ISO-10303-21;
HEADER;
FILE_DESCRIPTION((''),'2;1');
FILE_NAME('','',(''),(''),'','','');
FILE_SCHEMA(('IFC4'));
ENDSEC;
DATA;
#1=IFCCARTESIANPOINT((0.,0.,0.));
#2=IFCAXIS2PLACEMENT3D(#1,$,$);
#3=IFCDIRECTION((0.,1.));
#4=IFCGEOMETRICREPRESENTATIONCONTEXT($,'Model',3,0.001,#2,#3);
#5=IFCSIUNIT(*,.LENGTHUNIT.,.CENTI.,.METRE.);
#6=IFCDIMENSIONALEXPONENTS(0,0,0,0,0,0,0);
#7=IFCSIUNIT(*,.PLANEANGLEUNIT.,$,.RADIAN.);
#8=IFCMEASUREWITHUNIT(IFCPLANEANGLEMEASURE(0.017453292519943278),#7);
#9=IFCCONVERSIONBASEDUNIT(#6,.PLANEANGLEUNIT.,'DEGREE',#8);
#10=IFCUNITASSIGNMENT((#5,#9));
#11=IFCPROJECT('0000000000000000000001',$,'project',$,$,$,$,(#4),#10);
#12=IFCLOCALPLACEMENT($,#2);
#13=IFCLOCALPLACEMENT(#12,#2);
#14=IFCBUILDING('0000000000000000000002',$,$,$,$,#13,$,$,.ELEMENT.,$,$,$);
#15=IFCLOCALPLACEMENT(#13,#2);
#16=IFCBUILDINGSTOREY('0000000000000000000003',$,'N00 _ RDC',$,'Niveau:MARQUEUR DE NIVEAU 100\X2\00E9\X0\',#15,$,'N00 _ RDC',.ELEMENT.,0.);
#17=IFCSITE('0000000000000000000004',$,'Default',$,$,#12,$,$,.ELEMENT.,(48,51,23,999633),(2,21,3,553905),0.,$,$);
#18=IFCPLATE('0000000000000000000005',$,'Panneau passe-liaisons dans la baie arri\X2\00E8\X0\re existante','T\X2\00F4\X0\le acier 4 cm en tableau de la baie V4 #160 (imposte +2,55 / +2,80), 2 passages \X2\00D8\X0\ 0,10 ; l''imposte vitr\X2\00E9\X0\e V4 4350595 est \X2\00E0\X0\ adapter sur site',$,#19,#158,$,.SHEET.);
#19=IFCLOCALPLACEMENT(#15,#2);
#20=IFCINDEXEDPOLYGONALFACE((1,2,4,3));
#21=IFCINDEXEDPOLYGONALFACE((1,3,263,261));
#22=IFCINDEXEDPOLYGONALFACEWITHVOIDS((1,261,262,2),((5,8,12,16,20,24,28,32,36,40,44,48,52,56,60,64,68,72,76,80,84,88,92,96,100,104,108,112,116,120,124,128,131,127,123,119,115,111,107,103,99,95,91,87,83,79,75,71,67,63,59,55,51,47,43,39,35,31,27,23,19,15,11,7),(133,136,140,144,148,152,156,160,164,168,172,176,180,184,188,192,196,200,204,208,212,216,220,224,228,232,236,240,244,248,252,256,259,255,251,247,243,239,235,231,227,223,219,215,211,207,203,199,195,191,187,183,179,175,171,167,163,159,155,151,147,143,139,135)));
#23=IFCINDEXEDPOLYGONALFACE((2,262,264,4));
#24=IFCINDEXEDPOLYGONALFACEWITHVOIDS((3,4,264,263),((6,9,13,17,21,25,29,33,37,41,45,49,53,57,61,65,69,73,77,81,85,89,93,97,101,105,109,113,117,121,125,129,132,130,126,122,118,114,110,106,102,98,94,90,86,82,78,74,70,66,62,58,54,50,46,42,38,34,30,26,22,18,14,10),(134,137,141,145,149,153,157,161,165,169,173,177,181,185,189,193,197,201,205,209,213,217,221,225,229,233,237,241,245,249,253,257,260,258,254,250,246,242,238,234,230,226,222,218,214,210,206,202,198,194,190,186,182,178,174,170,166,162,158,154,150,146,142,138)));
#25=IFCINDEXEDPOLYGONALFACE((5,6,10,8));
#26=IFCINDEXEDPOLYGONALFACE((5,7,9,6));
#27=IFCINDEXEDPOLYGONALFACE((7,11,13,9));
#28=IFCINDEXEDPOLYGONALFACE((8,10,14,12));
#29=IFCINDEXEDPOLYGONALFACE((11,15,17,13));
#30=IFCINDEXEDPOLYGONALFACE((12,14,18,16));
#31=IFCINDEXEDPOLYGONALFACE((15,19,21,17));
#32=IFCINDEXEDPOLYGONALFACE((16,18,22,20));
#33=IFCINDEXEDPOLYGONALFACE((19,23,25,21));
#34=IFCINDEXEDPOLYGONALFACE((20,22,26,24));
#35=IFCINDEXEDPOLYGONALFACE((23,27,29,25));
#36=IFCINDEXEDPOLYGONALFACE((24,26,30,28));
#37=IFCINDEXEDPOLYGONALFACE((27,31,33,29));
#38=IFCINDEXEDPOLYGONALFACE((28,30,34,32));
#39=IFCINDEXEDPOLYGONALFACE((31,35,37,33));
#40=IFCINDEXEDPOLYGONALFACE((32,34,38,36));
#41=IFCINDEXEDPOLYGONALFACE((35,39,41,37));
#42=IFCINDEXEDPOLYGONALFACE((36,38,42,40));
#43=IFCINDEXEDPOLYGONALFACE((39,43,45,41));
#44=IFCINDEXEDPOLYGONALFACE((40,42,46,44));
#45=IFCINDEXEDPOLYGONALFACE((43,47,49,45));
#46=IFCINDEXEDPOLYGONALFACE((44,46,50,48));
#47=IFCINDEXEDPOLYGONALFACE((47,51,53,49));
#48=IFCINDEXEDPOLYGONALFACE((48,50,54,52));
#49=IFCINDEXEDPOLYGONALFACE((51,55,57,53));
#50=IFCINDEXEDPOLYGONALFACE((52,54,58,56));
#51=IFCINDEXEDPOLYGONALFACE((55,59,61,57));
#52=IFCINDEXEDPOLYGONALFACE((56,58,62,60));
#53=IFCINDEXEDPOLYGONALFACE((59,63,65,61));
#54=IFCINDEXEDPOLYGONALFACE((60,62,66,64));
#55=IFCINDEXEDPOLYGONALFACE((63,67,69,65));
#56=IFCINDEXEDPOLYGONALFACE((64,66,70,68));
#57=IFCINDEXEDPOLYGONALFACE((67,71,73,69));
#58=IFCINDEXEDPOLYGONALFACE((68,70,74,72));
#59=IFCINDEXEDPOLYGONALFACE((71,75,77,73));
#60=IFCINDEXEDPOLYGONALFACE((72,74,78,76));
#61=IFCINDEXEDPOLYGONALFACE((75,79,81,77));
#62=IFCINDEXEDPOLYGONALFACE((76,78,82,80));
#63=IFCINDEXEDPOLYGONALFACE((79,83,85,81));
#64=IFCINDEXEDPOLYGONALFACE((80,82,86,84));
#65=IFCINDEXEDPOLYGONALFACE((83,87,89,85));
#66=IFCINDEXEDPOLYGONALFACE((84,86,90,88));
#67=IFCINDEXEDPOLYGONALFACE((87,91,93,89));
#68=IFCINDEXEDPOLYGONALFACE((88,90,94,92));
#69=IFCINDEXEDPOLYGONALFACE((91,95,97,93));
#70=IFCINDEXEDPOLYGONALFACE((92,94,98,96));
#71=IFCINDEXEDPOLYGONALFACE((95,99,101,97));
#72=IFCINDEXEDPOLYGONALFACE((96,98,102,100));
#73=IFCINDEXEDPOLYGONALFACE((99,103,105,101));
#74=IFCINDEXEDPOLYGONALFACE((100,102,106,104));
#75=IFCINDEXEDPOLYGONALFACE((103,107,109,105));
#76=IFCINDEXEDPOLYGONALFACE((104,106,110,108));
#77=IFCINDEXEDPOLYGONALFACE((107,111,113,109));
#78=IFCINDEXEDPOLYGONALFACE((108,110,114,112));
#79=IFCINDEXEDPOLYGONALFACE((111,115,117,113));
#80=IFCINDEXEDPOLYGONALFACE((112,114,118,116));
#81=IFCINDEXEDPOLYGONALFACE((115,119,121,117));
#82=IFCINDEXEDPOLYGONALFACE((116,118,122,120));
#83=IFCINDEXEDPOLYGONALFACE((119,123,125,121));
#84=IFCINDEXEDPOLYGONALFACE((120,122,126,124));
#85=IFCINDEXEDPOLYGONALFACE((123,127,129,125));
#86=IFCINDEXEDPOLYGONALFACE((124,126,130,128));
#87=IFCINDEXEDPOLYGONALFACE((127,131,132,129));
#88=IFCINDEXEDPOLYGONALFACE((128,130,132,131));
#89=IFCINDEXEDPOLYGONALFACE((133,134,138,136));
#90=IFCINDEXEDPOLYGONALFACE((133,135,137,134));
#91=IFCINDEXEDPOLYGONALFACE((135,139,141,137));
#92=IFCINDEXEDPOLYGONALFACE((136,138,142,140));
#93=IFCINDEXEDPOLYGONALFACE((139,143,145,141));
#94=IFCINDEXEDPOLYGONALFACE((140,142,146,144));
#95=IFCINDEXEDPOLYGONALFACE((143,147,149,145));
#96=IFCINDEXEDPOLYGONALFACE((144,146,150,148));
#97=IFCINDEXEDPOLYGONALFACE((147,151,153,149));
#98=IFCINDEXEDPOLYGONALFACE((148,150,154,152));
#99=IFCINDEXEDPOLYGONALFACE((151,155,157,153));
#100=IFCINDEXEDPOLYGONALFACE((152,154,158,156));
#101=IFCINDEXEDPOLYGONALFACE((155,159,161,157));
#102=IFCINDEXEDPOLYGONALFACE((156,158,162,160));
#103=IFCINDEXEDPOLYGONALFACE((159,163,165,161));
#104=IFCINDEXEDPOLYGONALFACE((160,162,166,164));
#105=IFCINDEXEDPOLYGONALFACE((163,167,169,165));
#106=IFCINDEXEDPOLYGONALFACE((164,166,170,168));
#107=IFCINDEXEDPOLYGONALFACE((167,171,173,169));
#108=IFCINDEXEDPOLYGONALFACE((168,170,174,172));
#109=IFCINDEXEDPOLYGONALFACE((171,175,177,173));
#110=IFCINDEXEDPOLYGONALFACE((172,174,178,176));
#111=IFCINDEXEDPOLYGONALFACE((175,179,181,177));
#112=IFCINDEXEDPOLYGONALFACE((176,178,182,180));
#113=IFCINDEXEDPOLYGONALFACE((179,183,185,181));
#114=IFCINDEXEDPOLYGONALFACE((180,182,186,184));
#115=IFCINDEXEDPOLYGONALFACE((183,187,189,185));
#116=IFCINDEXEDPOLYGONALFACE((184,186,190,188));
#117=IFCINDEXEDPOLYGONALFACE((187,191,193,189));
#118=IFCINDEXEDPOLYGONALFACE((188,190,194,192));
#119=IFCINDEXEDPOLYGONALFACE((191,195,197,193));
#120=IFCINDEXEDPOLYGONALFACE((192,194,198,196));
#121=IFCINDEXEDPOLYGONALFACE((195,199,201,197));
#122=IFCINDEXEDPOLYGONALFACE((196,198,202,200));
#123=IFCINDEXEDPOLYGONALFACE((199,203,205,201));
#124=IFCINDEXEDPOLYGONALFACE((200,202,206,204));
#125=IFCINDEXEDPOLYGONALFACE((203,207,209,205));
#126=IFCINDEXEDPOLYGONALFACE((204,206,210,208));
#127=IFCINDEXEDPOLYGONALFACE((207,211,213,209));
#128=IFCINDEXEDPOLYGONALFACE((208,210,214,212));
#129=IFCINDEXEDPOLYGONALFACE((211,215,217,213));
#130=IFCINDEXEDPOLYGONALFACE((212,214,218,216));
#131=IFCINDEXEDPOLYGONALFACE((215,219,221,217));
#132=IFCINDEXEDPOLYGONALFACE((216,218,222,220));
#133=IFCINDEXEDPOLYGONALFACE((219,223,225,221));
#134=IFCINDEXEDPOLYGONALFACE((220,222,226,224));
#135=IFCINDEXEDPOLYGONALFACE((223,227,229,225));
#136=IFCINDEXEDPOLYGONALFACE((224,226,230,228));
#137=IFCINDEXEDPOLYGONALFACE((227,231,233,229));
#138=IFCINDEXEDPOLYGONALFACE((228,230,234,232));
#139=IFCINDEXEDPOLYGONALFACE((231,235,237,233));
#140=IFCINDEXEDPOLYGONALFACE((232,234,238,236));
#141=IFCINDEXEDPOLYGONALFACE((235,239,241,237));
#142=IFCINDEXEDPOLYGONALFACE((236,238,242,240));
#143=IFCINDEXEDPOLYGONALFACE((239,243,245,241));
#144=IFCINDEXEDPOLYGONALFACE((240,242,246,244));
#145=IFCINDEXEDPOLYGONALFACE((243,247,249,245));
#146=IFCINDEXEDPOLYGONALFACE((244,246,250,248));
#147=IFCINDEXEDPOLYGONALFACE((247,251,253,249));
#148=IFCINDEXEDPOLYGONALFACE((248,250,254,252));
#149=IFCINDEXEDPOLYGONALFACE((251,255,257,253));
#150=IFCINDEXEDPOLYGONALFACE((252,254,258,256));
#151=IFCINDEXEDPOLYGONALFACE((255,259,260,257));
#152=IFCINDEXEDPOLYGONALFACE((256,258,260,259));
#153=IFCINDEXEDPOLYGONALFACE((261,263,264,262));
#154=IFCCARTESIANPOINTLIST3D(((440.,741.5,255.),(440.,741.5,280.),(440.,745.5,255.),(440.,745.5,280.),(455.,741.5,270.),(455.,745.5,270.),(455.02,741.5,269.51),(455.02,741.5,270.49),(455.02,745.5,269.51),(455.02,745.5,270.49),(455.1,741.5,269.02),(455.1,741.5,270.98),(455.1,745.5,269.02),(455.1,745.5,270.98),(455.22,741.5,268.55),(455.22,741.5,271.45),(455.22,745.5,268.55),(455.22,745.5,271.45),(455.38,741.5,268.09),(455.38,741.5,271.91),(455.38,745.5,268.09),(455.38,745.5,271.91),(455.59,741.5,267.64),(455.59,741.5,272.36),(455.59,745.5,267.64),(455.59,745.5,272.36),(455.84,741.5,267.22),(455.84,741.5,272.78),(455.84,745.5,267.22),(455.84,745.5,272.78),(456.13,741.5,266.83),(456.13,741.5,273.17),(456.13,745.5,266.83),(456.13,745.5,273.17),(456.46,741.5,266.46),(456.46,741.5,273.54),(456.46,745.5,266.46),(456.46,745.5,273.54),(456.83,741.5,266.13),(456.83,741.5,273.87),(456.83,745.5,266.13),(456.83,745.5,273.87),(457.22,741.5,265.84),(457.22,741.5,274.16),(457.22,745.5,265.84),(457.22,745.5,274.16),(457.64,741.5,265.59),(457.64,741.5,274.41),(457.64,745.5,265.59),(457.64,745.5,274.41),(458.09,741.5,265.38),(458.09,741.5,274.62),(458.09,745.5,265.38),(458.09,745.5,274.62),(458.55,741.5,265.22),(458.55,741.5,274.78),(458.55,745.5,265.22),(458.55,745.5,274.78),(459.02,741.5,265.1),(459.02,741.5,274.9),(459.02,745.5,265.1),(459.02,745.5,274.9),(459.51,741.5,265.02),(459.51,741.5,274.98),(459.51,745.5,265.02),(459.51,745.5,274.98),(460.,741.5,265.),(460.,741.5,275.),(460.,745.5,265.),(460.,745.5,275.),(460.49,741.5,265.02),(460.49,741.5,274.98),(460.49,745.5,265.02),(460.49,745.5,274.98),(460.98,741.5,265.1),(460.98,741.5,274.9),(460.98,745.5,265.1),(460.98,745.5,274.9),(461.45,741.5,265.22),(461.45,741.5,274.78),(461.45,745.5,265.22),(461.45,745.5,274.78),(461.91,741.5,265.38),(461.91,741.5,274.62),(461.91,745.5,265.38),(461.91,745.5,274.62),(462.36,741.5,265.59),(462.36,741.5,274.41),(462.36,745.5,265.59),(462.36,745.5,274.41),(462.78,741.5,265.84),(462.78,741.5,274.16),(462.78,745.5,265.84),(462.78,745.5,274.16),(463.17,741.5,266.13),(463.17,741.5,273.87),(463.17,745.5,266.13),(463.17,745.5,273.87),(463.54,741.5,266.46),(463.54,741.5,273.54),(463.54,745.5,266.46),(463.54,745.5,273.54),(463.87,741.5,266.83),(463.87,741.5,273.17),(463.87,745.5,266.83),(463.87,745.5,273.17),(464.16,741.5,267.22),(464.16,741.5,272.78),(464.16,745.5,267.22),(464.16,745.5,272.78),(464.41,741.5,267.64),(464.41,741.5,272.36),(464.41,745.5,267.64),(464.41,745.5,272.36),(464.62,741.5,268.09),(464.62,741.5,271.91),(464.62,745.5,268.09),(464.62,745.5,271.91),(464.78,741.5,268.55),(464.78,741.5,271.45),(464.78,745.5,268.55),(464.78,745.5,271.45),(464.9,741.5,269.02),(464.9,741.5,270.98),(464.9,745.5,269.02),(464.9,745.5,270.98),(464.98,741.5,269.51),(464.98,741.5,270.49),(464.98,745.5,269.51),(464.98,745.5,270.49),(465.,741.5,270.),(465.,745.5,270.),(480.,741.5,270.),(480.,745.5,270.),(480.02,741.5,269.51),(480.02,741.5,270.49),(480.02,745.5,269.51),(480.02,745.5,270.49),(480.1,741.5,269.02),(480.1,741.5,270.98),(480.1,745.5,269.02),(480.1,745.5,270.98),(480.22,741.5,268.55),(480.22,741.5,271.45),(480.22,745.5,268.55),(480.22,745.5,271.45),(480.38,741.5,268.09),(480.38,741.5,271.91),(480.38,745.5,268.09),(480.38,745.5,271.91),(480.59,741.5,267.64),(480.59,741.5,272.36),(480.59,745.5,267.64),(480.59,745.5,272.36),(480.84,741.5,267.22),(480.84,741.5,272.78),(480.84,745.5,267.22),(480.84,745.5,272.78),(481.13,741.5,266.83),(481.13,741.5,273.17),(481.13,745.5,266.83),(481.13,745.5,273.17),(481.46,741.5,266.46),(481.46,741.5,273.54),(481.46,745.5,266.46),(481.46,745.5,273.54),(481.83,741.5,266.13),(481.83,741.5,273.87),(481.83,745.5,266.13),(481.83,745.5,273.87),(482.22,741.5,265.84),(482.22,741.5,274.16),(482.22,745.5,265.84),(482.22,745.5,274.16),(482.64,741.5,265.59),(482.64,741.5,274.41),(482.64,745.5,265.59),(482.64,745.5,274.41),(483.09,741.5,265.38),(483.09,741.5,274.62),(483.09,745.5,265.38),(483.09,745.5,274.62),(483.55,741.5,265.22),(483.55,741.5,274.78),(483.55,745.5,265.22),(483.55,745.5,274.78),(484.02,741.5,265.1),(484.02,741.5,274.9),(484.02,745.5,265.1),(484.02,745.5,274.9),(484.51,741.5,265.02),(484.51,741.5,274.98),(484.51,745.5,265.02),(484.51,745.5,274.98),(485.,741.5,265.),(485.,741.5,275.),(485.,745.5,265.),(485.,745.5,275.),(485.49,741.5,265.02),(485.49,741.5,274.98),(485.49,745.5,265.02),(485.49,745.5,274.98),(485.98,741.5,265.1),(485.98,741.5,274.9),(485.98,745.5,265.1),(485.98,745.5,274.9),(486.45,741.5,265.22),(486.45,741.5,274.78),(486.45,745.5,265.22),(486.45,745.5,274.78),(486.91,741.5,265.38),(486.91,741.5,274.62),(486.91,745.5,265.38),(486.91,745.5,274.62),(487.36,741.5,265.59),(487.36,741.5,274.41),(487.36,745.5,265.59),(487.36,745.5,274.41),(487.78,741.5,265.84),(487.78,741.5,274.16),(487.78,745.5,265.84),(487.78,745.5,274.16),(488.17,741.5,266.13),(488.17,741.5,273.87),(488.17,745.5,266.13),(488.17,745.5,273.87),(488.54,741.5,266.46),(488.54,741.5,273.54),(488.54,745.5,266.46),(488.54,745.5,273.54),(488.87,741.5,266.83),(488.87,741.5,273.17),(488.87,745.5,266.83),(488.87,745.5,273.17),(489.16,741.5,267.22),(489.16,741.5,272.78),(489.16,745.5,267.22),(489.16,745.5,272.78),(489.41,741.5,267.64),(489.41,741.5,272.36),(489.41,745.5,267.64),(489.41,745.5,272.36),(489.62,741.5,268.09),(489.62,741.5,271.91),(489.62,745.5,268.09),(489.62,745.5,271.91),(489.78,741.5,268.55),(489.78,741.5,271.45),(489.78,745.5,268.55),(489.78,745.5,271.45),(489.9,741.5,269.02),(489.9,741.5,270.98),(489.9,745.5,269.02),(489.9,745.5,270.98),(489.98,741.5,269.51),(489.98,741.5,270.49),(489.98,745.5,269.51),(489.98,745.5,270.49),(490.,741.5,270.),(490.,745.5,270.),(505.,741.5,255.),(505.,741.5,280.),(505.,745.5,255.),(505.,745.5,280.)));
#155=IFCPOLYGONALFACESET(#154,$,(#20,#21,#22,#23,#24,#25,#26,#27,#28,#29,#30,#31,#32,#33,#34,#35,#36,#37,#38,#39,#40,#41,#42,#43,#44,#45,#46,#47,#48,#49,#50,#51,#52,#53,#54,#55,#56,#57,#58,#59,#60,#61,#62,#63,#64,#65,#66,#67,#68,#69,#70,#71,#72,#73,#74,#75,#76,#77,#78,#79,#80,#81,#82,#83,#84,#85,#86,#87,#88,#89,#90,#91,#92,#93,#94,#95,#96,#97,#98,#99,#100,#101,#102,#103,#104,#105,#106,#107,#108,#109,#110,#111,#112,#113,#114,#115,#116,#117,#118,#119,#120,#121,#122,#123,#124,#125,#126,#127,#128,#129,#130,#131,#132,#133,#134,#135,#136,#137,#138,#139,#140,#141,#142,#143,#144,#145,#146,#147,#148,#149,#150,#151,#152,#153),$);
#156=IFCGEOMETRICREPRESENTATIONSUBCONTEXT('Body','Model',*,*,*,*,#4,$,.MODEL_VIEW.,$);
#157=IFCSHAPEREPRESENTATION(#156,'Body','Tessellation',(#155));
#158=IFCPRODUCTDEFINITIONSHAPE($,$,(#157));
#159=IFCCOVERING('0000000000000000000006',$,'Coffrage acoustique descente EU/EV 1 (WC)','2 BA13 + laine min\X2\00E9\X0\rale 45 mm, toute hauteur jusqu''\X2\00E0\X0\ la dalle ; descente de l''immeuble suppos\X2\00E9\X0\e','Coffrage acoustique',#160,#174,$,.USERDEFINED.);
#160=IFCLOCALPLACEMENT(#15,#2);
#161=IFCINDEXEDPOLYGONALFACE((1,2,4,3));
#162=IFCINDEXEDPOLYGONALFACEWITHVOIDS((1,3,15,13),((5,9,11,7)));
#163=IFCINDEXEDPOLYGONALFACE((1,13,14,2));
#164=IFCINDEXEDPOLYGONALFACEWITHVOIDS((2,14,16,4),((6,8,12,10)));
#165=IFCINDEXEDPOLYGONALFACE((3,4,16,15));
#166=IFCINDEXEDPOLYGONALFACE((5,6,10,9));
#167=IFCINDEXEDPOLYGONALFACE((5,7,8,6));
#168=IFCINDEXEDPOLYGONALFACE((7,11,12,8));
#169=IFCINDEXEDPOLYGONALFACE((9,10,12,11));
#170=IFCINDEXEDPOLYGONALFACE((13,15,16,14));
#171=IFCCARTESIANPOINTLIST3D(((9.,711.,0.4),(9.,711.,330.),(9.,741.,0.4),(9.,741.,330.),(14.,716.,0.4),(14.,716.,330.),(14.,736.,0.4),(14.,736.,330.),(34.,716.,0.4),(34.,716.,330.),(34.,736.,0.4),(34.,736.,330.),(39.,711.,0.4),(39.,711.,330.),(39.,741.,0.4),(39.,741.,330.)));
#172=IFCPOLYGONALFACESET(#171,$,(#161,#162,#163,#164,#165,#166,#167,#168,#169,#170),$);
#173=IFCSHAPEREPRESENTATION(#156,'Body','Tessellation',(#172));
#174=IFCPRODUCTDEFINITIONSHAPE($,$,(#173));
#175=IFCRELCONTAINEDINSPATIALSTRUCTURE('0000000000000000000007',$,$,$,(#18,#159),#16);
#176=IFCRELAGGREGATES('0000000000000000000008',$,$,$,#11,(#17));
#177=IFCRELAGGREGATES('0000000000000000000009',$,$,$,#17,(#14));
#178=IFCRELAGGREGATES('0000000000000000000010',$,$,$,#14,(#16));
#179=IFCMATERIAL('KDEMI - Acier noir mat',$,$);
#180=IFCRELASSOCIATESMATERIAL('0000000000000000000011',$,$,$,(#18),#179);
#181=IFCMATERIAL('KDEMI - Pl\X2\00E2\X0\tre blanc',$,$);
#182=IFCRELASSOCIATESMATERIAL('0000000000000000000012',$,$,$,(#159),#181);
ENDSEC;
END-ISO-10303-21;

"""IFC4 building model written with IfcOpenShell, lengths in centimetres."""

from ifc_helpers import new_model, entity, si_unit, converted_unit, direction, frame, frame_2d, origin, origin_with_axes, place, context, subcontext, project, spatial, polyline, hollow_rectangle, outline, extrude, material, element, save


model = new_model("IFC4")

# Units and contexts
model_context = context("Model", 3, precision=0.001, world=origin(), true_north=direction((0.0, 1.0)))
body_context = subcontext(model_context, "Body", "Model", "MODEL_VIEW")
ifc_project = project(units=[si_unit("LENGTHUNIT", "METRE", prefix="CENTI"), converted_unit("PLANEANGLEUNIT", "DEGREE", entity("IfcPlaneAngleMeasure", 0.017453292519943278), si_unit("PLANEANGLEUNIT", "RADIAN"), dimensions=[0, 0, 0, 0, 0, 0, 0])], contexts=[model_context])

# Site, building, storey
site_placement = place(None, origin())
site = spatial("IfcSite", under=ifc_project, at=site_placement, Name="Default", CompositionType="ELEMENT", RefLatitude=(48, 51, 23, 999633), RefLongitude=(2, 21, 3, 553905), RefElevation=0.0)
building_placement = place(site_placement, origin())
building = spatial("IfcBuilding", under=site, at=building_placement, CompositionType="ELEMENT")
storey_placement = place(building_placement, origin())
storey = spatial("IfcBuildingStorey", under=building, at=storey_placement, Name="N00 _ RDC", ObjectType="Niveau:MARQUEUR DE NIVEAU 100é", LongName="N00 _ RDC", CompositionType="ELEMENT", Elevation=0.0)

# Plate
ifc_material_1 = material(Name="KDEMI - Acier noir mat")
plate_placement = place(storey_placement, origin_with_axes())
element("IfcPlate", 1, at=plate_placement, inside=storey, material=ifc_material_1, Name="Panneau passe-liaisons dans la baie arrière existante", Description="Tôle acier 4 cm en tableau de la baie V4 #160 (imposte +2,55 / +2,80), 2 passages Ø 0,10 ; l'imposte vitrée V4 4350595 est à adapter sur site", PredefinedType="SHEET", context=body_context, shape_type="SweptSolid", body=[
    extrude(outline(polyline([(440.0, 255.0), (440.0, 280.0), (505.0, 280.0), (505.0, 255.0), (440.0, 255.0)]), holes=[polyline([(490.0, 270.0), (489.98, 270.49), (489.9, 270.98), (489.78, 271.45), (489.62, 271.91), (489.41, 272.36), (489.16, 272.78), (488.87, 273.17), (488.54, 273.54), (488.17, 273.87), (487.78, 274.16), (487.36, 274.41), (486.91, 274.62), (486.45, 274.78), (485.98, 274.9), (485.49, 274.98), (485.0, 275.0), (484.51, 274.98), (484.02, 274.9), (483.55, 274.78), (483.09, 274.62), (482.64, 274.41), (482.22, 274.16), (481.83, 273.87), (481.46, 273.54), (481.13, 273.17), (480.84, 272.78), (480.59, 272.36), (480.38, 271.91), (480.22, 271.45), (480.1, 270.98), (480.02, 270.49), (480.0, 270.0), (480.02, 269.51), (480.1, 269.02), (480.22, 268.55), (480.38, 268.09), (480.59, 267.64), (480.84, 267.22), (481.13, 266.83), (481.46, 266.46), (481.83, 266.13), (482.22, 265.84), (482.64, 265.59), (483.09, 265.38), (483.55, 265.22), (484.02, 265.1), (484.51, 265.02), (485.0, 265.0), (485.49, 265.02), (485.98, 265.1), (486.45, 265.22), (486.91, 265.38), (487.36, 265.59), (487.78, 265.84), (488.17, 266.13), (488.54, 266.46), (488.87, 266.83), (489.16, 267.22), (489.41, 267.64), (489.62, 268.09), (489.78, 268.55), (489.9, 269.02), (489.98, 269.51), (490.0, 270.0)]), polyline([(465.0, 270.0), (464.98, 270.49), (464.9, 270.98), (464.78, 271.45), (464.62, 271.91), (464.41, 272.36), (464.16, 272.78), (463.87, 273.17), (463.54, 273.54), (463.17, 273.87), (462.78, 274.16), (462.36, 274.41), (461.91, 274.62), (461.45, 274.78), (460.98, 274.9), (460.49, 274.98), (460.0, 275.0), (459.51, 274.98), (459.02, 274.9), (458.55, 274.78), (458.09, 274.62), (457.64, 274.41), (457.22, 274.16), (456.83, 273.87), (456.46, 273.54), (456.13, 273.17), (455.84, 272.78), (455.59, 272.36), (455.38, 271.91), (455.22, 271.45), (455.1, 270.98), (455.02, 270.49), (455.0, 270.0), (455.02, 269.51), (455.1, 269.02), (455.22, 268.55), (455.38, 268.09), (455.59, 267.64), (455.84, 267.22), (456.13, 266.83), (456.46, 266.46), (456.83, 266.13), (457.22, 265.84), (457.64, 265.59), (458.09, 265.38), (458.55, 265.22), (459.02, 265.1), (459.51, 265.02), (460.0, 265.0), (460.49, 265.02), (460.98, 265.1), (461.45, 265.22), (461.91, 265.38), (462.36, 265.59), (462.78, 265.84), (463.17, 266.13), (463.54, 266.46), (463.87, 266.83), (464.16, 267.22), (464.41, 267.64), (464.62, 268.09), (464.78, 268.55), (464.9, 269.02), (464.98, 269.51), (465.0, 270.0)])]), frame((0.0, 745.5, 0.0), z_axis=(0.0, -1.0, 0.0), x_axis=(1.0, 0.0, 0.0)), (0.0, 0.0, 1.0), 4.0),
])

# Covering
ifc_material_2 = material(Name="KDEMI - Plâtre blanc")
covering_1_placement = place(storey_placement, origin_with_axes())
element("IfcCovering", 2, at=covering_1_placement, inside=storey, material=ifc_material_2, Name="Coffrage acoustique descente EU/EV 1 (WC)", Description="2 BA13 + laine minérale 45 mm, toute hauteur jusqu'à la dalle ; descente de l'immeuble supposée", ObjectType="Coffrage acoustique", PredefinedType="USERDEFINED", context=body_context, shape_type="SweptSolid", body=[
    extrude(hollow_rectangle(XDim=30.0, YDim=30.0, WallThickness=5.0, at=frame_2d((24.0, 726.0))), frame((0.0, 0.0, 0.4)), (0.0, 0.0, 1.0), 329.6),
])

save(model, "model.ifc")
